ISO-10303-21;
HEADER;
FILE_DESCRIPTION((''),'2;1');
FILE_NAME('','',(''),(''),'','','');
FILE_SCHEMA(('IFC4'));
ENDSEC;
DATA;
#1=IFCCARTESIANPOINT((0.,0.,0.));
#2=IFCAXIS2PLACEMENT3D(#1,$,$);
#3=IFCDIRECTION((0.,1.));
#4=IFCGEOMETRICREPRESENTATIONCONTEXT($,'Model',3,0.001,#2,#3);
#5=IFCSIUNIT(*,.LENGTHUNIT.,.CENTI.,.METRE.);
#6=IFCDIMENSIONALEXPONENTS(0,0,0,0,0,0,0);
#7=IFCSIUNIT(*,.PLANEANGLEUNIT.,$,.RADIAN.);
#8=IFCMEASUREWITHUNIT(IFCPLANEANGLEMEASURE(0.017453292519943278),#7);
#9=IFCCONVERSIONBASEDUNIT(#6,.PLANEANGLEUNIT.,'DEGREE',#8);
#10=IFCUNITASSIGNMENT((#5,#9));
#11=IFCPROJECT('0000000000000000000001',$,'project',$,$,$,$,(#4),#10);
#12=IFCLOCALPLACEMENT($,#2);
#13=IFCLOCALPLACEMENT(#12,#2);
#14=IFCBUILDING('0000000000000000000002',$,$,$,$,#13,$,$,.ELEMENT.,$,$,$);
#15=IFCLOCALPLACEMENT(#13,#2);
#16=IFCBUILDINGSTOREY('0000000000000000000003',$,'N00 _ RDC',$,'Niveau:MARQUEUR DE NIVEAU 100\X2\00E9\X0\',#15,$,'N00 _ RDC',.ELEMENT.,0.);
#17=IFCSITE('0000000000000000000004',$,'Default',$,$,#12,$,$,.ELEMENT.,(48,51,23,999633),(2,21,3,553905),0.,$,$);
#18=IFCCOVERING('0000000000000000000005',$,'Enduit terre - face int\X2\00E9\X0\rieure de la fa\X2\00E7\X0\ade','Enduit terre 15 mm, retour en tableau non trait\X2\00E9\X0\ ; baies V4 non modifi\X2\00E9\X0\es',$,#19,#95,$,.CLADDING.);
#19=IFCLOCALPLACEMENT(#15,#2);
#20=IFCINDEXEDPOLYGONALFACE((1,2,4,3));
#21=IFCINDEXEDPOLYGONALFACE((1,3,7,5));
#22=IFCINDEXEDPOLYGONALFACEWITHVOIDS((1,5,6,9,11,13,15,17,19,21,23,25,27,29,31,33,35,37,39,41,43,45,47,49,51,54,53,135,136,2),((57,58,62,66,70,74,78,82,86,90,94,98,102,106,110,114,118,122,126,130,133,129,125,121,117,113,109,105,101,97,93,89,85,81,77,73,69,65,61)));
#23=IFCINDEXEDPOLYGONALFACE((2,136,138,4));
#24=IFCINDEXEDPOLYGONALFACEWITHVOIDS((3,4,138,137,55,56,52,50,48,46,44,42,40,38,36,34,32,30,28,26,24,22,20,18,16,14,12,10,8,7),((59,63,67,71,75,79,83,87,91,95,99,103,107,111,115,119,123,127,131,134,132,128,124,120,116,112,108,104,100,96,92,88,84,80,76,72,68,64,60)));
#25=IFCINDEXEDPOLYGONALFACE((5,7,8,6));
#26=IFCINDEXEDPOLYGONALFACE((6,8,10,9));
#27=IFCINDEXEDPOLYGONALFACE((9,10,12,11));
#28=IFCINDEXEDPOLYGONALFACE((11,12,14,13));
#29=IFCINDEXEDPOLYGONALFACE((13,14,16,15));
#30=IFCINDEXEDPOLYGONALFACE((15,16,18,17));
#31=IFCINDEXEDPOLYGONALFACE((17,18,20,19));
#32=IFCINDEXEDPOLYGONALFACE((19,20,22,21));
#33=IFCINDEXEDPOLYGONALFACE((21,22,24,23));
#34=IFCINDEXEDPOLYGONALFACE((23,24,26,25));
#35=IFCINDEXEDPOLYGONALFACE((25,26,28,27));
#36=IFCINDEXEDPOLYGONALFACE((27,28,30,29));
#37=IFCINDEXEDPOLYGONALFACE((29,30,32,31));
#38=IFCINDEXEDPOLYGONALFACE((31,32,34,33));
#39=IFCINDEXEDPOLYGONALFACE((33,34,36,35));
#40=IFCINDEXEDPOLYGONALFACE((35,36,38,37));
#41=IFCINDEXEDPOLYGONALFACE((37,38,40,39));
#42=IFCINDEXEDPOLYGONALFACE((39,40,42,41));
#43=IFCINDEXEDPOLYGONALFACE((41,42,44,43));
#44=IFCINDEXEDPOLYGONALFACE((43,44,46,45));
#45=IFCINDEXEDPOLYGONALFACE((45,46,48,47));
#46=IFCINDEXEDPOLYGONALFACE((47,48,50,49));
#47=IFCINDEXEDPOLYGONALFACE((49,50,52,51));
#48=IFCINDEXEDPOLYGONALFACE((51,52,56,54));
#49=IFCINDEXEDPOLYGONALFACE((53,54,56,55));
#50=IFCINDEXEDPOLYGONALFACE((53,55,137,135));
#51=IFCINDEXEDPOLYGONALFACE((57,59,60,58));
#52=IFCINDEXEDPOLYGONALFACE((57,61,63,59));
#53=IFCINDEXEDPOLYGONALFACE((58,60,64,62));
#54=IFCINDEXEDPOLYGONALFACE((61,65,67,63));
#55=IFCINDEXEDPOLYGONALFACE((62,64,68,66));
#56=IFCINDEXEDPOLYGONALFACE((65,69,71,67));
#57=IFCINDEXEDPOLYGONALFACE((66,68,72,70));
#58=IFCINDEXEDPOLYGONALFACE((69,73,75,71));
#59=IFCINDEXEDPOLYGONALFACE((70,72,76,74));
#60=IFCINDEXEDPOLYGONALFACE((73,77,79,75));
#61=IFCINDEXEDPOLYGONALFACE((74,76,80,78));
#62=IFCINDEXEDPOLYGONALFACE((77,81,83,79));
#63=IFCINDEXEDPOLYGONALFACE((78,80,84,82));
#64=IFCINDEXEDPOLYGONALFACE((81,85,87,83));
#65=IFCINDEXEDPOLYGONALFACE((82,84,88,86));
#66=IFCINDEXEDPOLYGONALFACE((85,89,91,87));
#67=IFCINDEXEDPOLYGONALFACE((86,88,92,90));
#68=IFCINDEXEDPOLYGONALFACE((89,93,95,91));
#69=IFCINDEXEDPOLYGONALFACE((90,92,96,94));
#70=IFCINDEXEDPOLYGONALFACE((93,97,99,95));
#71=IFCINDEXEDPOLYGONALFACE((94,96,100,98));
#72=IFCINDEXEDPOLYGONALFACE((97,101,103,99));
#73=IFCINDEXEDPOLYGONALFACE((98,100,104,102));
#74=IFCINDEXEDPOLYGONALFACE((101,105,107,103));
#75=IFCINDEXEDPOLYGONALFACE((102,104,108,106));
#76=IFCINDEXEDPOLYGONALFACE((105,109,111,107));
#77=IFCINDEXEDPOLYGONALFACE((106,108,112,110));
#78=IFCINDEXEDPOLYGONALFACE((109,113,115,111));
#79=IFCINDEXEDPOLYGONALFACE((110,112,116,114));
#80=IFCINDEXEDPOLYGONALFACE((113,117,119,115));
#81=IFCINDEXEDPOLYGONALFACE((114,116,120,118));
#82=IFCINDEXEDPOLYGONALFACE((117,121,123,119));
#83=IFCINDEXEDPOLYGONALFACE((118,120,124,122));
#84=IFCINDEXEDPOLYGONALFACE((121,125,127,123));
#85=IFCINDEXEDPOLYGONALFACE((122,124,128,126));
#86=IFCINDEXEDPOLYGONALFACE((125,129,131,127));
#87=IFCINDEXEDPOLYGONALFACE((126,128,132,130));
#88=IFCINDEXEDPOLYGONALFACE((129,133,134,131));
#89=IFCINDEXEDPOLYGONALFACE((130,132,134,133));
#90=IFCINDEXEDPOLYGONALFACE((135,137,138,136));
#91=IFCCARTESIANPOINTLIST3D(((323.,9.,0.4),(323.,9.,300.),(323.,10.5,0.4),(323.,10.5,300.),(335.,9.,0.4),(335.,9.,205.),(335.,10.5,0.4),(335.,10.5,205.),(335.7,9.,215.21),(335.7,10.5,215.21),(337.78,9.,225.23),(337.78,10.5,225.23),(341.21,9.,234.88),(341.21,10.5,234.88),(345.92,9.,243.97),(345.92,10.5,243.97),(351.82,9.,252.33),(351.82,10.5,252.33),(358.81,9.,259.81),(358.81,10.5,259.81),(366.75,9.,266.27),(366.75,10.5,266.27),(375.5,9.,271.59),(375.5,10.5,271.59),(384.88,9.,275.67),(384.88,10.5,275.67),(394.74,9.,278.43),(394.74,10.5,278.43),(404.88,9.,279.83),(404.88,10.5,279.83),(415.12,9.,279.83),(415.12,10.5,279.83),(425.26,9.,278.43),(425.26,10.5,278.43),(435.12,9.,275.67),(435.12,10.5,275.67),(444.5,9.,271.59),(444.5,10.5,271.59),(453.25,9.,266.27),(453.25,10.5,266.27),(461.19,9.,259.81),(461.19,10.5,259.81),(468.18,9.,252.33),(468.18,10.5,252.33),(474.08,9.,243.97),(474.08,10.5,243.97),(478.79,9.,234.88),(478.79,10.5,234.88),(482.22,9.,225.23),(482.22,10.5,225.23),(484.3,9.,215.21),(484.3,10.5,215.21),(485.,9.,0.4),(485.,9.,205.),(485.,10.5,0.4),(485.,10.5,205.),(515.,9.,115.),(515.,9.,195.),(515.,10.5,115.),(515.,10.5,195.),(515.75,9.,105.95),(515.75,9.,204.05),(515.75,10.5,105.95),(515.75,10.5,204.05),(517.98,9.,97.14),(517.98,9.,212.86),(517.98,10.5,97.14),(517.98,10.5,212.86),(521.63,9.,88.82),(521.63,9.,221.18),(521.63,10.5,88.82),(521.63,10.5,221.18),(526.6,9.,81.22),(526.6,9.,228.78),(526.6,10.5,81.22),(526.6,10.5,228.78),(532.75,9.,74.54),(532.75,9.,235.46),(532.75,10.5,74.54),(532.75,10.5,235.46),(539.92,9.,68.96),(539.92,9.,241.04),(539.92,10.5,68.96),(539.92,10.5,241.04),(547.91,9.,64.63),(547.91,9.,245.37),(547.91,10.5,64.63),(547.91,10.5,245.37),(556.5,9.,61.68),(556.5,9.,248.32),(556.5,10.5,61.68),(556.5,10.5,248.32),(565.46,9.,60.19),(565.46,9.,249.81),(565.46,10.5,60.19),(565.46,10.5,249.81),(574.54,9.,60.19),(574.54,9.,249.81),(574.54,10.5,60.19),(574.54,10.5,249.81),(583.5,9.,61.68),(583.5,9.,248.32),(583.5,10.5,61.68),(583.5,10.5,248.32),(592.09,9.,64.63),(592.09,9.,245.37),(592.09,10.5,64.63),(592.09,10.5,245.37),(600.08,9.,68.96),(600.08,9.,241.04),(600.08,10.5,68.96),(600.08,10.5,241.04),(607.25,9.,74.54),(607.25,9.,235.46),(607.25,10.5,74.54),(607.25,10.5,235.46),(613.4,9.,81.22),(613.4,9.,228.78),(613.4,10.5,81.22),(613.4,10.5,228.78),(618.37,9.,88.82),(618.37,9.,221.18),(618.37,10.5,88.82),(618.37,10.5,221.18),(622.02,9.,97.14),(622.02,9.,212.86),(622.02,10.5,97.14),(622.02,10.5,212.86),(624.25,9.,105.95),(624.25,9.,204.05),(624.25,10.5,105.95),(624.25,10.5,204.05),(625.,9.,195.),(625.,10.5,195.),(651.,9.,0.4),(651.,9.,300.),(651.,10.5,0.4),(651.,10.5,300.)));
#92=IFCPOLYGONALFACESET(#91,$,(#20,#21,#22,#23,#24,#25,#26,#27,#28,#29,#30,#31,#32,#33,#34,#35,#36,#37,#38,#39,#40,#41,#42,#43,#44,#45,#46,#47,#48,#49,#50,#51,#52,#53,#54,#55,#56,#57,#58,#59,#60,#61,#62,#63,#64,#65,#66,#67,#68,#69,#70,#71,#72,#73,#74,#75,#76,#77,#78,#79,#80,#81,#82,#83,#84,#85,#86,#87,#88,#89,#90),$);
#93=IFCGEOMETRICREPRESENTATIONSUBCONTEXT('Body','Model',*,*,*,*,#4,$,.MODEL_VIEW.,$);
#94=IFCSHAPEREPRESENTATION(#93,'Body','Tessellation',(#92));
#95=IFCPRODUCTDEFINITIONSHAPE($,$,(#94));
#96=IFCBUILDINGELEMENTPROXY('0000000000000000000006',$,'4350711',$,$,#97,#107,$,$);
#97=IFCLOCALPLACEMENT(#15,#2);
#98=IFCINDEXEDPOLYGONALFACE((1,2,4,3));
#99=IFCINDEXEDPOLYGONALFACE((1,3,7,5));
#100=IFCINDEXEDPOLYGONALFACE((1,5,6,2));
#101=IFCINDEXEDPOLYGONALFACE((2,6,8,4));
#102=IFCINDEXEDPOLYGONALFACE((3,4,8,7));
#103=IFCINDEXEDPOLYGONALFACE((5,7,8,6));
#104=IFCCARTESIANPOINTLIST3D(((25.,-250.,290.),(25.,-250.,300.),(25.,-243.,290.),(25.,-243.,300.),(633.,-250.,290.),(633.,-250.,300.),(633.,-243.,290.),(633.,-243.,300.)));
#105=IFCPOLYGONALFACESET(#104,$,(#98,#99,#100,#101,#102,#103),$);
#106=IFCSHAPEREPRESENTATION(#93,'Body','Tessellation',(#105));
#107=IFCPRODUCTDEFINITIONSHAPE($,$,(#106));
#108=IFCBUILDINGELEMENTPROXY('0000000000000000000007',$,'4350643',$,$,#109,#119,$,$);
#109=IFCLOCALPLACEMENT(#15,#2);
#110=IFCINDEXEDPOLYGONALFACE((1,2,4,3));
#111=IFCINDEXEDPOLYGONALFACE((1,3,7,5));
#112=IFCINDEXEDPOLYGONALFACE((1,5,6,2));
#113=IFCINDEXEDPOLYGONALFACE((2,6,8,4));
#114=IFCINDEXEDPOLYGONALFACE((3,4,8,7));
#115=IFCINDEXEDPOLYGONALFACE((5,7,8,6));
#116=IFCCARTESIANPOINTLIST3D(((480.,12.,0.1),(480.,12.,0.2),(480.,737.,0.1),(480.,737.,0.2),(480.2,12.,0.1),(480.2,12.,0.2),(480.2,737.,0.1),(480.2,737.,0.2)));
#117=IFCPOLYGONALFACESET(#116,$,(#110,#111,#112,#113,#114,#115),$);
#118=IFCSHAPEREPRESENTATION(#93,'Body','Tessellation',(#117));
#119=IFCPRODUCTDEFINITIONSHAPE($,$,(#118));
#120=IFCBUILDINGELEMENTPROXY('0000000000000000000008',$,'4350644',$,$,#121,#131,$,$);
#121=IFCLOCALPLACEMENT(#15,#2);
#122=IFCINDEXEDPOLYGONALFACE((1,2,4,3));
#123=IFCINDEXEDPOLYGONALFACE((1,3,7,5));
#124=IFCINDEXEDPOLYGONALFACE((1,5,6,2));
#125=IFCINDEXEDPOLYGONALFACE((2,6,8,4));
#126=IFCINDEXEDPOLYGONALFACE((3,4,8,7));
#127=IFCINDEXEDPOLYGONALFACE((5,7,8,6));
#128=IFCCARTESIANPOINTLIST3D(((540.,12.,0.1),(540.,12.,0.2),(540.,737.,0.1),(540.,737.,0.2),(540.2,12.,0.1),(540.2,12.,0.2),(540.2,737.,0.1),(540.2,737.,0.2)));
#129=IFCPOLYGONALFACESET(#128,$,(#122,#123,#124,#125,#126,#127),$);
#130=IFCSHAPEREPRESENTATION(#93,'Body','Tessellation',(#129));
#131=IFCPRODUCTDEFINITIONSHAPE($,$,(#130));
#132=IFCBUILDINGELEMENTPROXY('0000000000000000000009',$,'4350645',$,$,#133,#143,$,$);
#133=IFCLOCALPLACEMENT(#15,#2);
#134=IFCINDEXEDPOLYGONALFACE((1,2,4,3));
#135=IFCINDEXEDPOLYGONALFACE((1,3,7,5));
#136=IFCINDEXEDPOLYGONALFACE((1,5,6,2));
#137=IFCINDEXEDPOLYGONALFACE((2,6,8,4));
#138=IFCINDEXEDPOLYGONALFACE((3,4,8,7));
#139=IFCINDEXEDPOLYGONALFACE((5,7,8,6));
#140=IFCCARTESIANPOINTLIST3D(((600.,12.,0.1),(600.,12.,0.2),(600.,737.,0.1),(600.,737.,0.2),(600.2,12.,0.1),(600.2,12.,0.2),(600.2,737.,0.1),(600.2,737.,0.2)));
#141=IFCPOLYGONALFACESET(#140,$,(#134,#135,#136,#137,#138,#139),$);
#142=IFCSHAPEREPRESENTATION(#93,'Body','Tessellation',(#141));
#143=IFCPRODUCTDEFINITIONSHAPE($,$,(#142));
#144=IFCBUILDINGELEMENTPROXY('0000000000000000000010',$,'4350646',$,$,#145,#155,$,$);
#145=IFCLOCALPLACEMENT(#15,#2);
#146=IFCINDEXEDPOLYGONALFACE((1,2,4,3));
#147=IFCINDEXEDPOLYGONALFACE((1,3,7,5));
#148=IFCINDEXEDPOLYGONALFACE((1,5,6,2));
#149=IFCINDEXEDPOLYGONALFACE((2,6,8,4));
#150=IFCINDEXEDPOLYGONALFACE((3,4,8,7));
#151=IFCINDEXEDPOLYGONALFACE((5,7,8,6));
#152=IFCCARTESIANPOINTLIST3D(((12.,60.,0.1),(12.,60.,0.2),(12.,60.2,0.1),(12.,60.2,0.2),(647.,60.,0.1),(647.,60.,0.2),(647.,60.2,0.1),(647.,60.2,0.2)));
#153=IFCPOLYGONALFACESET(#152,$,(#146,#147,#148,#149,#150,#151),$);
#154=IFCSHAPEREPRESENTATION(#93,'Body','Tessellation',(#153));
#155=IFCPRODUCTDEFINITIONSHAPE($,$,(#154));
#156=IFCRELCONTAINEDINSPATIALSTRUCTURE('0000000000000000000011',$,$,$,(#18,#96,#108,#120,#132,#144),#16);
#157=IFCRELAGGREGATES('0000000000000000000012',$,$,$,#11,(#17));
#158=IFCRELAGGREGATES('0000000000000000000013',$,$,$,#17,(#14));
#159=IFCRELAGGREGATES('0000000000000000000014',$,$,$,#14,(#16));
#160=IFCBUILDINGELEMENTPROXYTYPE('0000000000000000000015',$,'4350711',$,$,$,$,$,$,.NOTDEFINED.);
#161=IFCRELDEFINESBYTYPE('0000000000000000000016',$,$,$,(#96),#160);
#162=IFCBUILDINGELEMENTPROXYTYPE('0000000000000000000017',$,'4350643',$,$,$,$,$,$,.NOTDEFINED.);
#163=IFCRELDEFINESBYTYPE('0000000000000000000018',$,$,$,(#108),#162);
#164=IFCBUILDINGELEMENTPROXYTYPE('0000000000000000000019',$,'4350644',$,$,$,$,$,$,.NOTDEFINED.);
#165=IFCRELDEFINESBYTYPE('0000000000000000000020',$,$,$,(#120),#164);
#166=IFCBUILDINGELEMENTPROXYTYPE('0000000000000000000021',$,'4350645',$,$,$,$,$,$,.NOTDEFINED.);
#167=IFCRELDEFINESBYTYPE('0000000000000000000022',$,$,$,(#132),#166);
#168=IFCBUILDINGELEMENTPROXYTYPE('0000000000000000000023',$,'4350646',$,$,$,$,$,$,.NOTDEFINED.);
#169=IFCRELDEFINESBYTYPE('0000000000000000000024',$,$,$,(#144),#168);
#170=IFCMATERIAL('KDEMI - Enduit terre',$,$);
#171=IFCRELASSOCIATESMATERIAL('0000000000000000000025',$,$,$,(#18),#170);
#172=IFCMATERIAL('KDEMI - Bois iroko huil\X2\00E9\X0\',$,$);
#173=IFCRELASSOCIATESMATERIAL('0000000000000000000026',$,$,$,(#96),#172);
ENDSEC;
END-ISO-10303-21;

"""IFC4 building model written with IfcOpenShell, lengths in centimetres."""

from ifc_helpers import new_model, entity, si_unit, converted_unit, direction, frame, frame_2d, origin, origin_with_axes, origin_2d_with_axis, place, context, subcontext, project, spatial, polyline, rectangle, outline, extrude, material, type_object, element, save


model = new_model("IFC4")

# Units and contexts
model_context = context("Model", 3, precision=0.001, world=origin(), true_north=direction((0.0, 1.0)))
body_context = subcontext(model_context, "Body", "Model", "MODEL_VIEW")
ifc_project = project(units=[si_unit("LENGTHUNIT", "METRE", prefix="CENTI"), converted_unit("PLANEANGLEUNIT", "DEGREE", entity("IfcPlaneAngleMeasure", 0.017453292519943278), si_unit("PLANEANGLEUNIT", "RADIAN"), dimensions=[0, 0, 0, 0, 0, 0, 0])], contexts=[model_context])

# Site, building, storey
site_placement = place(None, origin())
site = spatial("IfcSite", under=ifc_project, at=site_placement, Name="Default", CompositionType="ELEMENT", RefLatitude=(48, 51, 23, 999633), RefLongitude=(2, 21, 3, 553905), RefElevation=0.0)
building_placement = place(site_placement, origin())
building = spatial("IfcBuilding", under=site, at=building_placement, CompositionType="ELEMENT")
storey_placement = place(building_placement, origin())
storey = spatial("IfcBuildingStorey", under=building, at=storey_placement, Name="N00 _ RDC", ObjectType="Niveau:MARQUEUR DE NIVEAU 100é", LongName="N00 _ RDC", CompositionType="ELEMENT", Elevation=0.0)

# Shared definitions
ifc_material_1 = material(Name="KDEMI - Bois iroko huilé")

# Covering
ifc_material_2 = material(Name="KDEMI - Enduit terre")
covering_1_placement = place(storey_placement, origin_with_axes())
element("IfcCovering", 1, at=covering_1_placement, inside=storey, material=ifc_material_2, Name="Enduit terre - face intérieure de la façade", Description="Enduit terre 15 mm, retour en tableau non traité ; baies V4 non modifiées", PredefinedType="CLADDING", context=body_context, shape_type="SweptSolid", body=[
    extrude(outline(polyline([(323.0, 300.0), (651.0, 300.0), (651.0, 0.4), (485.0, 0.4), (485.0, 205.0), (484.3, 215.21), (482.22, 225.23), (478.79, 234.88), (474.08, 243.97), (468.18, 252.33), (461.19, 259.81), (453.25, 266.27), (444.5, 271.59), (435.12, 275.67), (425.26, 278.43), (415.12, 279.83), (404.88, 279.83), (394.74, 278.43), (384.88, 275.67), (375.5, 271.59), (366.75, 266.27), (358.81, 259.81), (351.82, 252.33), (345.92, 243.97), (341.21, 234.88), (337.78, 225.23), (335.7, 215.21), (335.0, 205.0), (335.0, 0.4), (323.0, 0.4), (323.0, 300.0)]), holes=[polyline([(624.25, 204.05), (622.02, 212.86), (618.37, 221.18), (613.4, 228.78), (607.25, 235.46), (600.08, 241.04), (592.09, 245.37), (583.5, 248.32), (574.54, 249.81), (565.46, 249.81), (556.5, 248.32), (547.91, 245.37), (539.92, 241.04), (532.75, 235.46), (526.6, 228.78), (521.63, 221.18), (517.98, 212.86), (515.75, 204.05), (515.0, 195.0), (515.0, 115.0), (515.75, 105.95), (517.98, 97.14), (521.63, 88.82), (526.6, 81.22), (532.75, 74.54), (539.92, 68.96), (547.91, 64.63), (556.5, 61.68), (565.46, 60.19), (574.54, 60.19), (583.5, 61.68), (592.09, 64.63), (600.08, 68.96), (607.25, 74.54), (613.4, 81.22), (618.37, 88.82), (622.02, 97.14), (624.25, 105.95), (625.0, 195.0), (624.25, 204.05)])]), frame((0.0, 10.5, 0.0), z_axis=(0.0, -1.0, 0.0), x_axis=(1.0, 0.0, 0.0)), (0.0, 0.0, 1.0), 1.5),
])

# Building element proxies
building_element_proxy_type_1 = type_object("IfcBuildingElementProxyType", Name="4350711", PredefinedType="NOTDEFINED")
proxy_1_placement = place(storey_placement, frame((0.0, 0.0, 25.0), z_axis=(0.0, 0.0, 1.0), x_axis=(1.0, 0.0, 0.0)))
element("IfcBuildingElementProxy", 2, at=proxy_1_placement, inside=storey, type_object=building_element_proxy_type_1, material=ifc_material_1, Name="4350711", context=body_context, shape_type="SweptSolid", body=[
    extrude(rectangle(XDim=608.0, YDim=7.0, at=frame_2d((0.0, 0.0), x_axis=(1.0, 0.0))), frame((329.0, -246.5, 265.0)), (0.0, 0.0, 1.0), 10.0),
])
building_element_proxy_type_2 = type_object("IfcBuildingElementProxyType", Name="4350643", PredefinedType="NOTDEFINED")
proxy_2_placement = place(storey_placement, origin())
element("IfcBuildingElementProxy", 3, at=proxy_2_placement, inside=storey, type_object=building_element_proxy_type_2, Name="4350643", context=body_context, shape_type="SweptSolid", body=[
    extrude(rectangle(XDim=0.2, YDim=725.0, at=origin_2d_with_axis()), frame((480.1, 374.5, 0.1)), (0.0, 0.0, 1.0), 0.1),
])
building_element_proxy_type_3 = type_object("IfcBuildingElementProxyType", Name="4350644", PredefinedType="NOTDEFINED")
proxy_3_placement = place(storey_placement, origin())
element("IfcBuildingElementProxy", 4, at=proxy_3_placement, inside=storey, type_object=building_element_proxy_type_3, Name="4350644", context=body_context, shape_type="SweptSolid", body=[
    extrude(rectangle(XDim=0.2, YDim=725.0, at=origin_2d_with_axis()), frame((540.1, 374.5, 0.1)), (0.0, 0.0, 1.0), 0.1),
])
building_element_proxy_type_4 = type_object("IfcBuildingElementProxyType", Name="4350645", PredefinedType="NOTDEFINED")
proxy_4_placement = place(storey_placement, origin())
element("IfcBuildingElementProxy", 5, at=proxy_4_placement, inside=storey, type_object=building_element_proxy_type_4, Name="4350645", context=body_context, shape_type="SweptSolid", body=[
    extrude(rectangle(XDim=0.2, YDim=725.0, at=origin_2d_with_axis()), frame((600.1, 374.5, 0.1)), (0.0, 0.0, 1.0), 0.1),
])
building_element_proxy_type_5 = type_object("IfcBuildingElementProxyType", Name="4350646", PredefinedType="NOTDEFINED")
proxy_5_placement = place(storey_placement, origin())
element("IfcBuildingElementProxy", 6, at=proxy_5_placement, inside=storey, type_object=building_element_proxy_type_5, Name="4350646", context=body_context, shape_type="SweptSolid", body=[
    extrude(rectangle(XDim=635.0, YDim=0.2, at=frame_2d((0.0, 0.0), x_axis=(1.0, 0.0))), frame((329.5, 60.1, 0.1)), (0.0, 0.0, 1.0), 0.1),
])

save(model, "model.ifc")
